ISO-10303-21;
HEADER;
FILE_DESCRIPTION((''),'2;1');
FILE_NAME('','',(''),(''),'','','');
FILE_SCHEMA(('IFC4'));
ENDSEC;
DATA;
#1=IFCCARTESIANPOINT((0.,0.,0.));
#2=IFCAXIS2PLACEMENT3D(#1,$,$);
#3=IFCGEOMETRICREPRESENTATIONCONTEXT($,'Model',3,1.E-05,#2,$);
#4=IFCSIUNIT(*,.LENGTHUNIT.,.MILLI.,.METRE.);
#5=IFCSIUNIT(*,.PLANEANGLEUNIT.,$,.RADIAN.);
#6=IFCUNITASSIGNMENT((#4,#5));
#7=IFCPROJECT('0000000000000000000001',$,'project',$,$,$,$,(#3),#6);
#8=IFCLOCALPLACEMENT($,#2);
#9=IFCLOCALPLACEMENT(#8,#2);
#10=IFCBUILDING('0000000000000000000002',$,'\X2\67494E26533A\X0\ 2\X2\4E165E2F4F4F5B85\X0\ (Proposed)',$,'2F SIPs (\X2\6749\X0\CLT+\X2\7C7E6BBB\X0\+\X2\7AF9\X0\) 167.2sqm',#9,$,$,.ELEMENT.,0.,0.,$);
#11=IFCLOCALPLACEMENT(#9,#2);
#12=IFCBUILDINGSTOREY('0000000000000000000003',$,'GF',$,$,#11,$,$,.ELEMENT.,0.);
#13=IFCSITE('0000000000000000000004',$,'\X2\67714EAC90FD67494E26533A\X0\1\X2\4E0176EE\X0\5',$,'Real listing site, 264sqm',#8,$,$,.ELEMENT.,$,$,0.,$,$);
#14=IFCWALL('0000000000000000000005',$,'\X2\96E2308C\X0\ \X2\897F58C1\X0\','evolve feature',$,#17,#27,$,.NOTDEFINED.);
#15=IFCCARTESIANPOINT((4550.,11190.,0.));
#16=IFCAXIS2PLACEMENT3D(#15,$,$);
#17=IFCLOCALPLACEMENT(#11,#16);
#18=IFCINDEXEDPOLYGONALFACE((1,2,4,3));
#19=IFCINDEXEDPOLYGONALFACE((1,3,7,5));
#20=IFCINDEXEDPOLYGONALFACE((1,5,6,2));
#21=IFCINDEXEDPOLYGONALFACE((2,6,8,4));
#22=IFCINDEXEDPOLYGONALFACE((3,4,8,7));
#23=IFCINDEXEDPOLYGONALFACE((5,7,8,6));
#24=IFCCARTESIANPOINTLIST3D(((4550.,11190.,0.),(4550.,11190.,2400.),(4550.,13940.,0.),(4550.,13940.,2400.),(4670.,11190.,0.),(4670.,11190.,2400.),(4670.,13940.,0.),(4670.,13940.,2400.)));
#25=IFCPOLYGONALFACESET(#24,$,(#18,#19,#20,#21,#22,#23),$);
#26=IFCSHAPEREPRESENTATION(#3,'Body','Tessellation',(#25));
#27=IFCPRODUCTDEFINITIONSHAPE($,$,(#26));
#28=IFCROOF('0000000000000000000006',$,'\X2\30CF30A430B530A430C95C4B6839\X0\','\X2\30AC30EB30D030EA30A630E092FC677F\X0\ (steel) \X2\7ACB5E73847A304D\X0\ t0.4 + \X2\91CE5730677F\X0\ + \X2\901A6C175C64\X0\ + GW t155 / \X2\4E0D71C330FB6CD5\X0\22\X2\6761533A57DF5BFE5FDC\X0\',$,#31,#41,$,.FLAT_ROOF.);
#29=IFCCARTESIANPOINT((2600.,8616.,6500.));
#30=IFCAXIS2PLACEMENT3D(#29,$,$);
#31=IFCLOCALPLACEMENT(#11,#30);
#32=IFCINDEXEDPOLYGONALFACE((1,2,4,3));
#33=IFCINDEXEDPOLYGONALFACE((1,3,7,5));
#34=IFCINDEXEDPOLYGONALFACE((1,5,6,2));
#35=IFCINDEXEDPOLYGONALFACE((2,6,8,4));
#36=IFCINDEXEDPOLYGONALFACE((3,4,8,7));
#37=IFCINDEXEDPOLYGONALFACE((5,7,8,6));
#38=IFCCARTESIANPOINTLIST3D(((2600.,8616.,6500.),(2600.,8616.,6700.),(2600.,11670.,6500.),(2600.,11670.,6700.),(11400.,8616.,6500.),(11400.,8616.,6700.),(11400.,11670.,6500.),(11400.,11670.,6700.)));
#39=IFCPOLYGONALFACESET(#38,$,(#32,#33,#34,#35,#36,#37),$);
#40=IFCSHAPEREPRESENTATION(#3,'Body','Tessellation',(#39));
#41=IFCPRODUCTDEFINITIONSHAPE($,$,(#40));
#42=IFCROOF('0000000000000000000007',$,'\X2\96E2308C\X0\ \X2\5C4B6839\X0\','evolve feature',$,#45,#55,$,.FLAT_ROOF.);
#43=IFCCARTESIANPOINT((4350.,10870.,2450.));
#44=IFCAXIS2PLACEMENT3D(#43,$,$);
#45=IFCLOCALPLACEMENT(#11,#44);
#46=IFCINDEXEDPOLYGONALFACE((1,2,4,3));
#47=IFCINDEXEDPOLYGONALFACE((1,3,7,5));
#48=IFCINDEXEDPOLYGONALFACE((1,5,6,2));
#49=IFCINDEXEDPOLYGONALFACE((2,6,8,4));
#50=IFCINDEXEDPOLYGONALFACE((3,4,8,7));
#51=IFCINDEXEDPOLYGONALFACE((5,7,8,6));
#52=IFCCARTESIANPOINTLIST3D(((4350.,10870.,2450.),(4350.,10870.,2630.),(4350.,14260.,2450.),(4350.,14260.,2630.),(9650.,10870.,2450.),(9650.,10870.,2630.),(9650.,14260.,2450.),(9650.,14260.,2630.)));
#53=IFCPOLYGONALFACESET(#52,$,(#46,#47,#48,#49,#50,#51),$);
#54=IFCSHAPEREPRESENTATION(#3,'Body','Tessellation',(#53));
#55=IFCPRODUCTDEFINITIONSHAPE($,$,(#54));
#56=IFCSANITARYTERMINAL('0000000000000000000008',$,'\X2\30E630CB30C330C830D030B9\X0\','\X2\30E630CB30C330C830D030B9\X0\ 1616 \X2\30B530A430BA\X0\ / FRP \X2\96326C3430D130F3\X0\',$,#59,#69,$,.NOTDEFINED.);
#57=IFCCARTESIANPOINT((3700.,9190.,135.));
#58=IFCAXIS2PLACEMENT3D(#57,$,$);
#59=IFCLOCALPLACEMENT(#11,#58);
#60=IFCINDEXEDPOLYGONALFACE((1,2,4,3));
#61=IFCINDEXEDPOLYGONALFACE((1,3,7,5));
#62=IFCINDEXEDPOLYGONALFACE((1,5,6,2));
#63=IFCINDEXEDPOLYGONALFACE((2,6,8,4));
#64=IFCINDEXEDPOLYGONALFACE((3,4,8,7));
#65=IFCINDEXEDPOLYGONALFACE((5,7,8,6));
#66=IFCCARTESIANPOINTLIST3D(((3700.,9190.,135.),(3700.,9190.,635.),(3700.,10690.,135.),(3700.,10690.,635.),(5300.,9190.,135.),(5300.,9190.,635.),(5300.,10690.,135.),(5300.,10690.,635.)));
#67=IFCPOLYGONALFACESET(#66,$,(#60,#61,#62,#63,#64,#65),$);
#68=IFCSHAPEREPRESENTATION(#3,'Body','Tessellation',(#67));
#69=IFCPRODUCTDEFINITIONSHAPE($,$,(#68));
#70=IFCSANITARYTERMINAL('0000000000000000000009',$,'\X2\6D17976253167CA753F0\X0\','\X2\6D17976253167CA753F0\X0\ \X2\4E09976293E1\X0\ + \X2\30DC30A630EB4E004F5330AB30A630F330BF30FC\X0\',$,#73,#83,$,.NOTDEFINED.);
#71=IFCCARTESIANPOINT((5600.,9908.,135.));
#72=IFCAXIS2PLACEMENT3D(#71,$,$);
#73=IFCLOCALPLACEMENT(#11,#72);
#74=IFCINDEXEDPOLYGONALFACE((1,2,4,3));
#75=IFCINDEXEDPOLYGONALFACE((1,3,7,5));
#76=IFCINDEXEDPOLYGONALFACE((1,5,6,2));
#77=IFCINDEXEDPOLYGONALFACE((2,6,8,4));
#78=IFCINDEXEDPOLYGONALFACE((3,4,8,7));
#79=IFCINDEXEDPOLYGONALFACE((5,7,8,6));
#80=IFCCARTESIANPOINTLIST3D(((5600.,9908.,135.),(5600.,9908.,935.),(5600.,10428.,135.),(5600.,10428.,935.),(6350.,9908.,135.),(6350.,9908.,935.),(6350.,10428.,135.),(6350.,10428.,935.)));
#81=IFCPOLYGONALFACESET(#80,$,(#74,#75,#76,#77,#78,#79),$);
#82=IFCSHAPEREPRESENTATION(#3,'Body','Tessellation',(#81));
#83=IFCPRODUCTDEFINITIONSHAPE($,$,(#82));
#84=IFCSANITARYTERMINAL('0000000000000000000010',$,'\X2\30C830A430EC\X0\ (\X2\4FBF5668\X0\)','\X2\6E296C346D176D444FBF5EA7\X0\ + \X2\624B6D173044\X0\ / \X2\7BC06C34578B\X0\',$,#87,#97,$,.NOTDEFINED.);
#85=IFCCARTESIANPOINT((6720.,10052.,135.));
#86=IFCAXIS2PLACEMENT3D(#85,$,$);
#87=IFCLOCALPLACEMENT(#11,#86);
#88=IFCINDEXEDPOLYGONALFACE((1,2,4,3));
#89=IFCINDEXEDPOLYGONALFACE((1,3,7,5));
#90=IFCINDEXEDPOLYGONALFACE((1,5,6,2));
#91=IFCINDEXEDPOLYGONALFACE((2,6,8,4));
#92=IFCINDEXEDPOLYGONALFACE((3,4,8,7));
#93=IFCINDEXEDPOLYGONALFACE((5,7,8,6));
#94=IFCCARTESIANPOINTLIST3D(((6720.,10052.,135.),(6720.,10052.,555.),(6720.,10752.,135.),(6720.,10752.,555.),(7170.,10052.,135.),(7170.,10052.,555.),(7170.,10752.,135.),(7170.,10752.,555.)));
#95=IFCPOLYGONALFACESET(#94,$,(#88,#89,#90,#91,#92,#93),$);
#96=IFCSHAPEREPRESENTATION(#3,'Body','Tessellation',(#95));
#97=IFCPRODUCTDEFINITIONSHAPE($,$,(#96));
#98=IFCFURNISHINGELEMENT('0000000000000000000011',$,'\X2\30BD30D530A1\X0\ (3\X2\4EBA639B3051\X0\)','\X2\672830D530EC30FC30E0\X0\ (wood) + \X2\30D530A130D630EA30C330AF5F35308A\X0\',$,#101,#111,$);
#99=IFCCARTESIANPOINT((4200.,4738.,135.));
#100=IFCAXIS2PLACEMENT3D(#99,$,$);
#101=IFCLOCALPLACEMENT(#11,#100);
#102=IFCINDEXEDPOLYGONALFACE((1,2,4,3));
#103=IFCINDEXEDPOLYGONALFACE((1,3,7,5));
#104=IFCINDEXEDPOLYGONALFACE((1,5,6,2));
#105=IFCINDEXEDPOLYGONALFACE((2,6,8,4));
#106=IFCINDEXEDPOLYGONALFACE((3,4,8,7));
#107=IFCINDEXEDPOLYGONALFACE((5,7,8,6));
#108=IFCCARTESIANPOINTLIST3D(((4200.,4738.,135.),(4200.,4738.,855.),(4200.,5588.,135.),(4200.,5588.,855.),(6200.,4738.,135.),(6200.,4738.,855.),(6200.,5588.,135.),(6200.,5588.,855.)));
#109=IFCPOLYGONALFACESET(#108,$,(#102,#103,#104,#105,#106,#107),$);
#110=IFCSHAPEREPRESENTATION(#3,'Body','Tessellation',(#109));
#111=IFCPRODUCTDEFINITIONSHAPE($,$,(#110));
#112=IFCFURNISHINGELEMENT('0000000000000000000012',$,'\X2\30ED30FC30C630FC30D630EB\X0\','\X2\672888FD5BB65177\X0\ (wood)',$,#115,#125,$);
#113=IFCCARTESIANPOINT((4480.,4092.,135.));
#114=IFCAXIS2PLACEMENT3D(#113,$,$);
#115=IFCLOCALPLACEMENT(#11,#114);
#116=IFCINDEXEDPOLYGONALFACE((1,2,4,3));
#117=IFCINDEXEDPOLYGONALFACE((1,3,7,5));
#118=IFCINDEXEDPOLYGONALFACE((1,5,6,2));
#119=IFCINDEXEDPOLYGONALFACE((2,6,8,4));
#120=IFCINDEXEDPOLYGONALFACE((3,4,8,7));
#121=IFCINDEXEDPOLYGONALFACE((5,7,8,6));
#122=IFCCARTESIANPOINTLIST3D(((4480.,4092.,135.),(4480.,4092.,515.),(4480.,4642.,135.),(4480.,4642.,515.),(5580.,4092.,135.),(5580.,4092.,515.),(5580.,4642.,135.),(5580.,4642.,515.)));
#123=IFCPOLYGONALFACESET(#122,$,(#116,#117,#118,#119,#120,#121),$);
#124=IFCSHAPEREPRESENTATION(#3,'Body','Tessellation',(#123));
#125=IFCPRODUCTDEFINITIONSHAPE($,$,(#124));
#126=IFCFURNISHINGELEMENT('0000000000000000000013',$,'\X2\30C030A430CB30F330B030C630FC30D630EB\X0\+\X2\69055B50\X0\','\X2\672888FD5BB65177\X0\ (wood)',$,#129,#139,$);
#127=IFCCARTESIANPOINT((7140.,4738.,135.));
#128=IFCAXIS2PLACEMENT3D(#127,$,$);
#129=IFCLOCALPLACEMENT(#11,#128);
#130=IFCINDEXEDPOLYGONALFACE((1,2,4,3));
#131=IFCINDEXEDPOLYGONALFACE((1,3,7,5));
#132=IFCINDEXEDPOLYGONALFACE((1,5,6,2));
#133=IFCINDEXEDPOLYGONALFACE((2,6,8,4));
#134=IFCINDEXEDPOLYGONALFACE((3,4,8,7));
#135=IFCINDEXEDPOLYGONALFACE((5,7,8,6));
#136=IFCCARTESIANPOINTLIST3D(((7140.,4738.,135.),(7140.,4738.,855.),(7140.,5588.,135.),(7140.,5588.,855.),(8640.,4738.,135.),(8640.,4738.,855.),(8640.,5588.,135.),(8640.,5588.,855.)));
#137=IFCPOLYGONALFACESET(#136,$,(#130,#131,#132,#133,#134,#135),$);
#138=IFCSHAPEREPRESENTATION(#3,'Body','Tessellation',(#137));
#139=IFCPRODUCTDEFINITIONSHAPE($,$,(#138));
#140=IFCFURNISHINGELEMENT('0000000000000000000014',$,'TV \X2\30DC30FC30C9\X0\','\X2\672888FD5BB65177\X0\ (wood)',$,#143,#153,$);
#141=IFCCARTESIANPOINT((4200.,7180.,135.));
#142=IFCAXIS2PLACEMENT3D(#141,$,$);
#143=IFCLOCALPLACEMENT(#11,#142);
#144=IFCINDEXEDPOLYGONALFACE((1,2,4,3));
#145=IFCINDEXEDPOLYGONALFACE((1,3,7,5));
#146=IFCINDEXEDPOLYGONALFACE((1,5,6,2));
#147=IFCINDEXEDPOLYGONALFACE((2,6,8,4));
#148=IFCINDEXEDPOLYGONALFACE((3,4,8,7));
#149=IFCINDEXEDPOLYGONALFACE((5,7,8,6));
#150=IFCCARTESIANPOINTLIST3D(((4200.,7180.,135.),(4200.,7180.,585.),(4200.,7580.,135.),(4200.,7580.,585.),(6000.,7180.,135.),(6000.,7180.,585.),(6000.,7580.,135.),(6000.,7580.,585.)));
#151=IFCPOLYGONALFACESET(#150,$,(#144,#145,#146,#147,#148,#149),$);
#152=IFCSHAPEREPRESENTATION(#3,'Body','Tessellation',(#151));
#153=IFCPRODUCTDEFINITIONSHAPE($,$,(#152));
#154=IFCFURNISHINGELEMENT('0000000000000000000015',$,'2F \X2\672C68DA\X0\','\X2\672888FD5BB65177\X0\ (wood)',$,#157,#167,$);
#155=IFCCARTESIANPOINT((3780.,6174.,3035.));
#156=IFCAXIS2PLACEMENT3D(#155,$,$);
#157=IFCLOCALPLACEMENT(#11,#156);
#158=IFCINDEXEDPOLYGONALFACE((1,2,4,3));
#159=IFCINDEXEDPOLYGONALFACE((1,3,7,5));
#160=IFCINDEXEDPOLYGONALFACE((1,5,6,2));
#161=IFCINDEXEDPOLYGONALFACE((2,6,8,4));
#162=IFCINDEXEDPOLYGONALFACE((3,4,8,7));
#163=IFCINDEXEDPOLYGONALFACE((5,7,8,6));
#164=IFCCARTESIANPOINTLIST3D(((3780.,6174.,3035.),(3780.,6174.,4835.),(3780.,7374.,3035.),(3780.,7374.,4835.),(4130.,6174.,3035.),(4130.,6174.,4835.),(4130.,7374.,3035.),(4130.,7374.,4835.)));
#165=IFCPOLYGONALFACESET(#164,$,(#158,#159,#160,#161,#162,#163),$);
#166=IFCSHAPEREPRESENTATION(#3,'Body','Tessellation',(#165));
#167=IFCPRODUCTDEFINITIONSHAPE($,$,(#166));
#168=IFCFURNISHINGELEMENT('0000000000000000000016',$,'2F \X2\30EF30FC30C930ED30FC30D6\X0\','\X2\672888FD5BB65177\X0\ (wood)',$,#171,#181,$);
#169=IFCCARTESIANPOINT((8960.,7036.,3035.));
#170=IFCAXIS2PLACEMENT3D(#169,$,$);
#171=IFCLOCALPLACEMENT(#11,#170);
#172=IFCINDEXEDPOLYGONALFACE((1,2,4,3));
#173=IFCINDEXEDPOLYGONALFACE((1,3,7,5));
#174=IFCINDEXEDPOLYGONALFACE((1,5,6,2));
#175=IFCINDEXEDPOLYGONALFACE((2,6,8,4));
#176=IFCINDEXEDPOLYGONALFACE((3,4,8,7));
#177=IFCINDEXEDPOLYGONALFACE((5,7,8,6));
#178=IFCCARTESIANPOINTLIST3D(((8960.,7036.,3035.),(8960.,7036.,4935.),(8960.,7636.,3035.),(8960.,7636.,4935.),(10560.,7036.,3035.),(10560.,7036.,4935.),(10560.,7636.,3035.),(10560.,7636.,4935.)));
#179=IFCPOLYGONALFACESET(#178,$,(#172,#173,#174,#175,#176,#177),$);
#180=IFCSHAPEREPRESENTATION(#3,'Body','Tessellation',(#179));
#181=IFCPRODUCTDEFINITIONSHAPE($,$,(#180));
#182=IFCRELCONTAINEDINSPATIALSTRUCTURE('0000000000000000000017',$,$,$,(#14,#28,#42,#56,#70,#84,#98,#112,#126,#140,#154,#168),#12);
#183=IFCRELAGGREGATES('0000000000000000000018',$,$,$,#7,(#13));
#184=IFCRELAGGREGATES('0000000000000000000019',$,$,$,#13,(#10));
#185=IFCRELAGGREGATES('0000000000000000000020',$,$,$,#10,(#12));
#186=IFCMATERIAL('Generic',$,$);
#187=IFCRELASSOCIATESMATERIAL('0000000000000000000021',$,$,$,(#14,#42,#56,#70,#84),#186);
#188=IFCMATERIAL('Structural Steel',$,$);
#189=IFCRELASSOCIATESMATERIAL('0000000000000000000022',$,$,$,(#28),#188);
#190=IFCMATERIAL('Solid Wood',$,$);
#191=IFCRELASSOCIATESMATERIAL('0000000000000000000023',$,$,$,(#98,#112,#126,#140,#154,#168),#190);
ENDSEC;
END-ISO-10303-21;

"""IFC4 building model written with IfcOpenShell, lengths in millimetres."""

from ifc_helpers import new_model, si_unit, frame, frame_2d, origin, place, context, project, spatial, rectangle, extrude, material, element, save


model = new_model("IFC4")

# Units and contexts
model_context = context("Model", 3, precision=1e-05, world=origin())
ifc_project = project(units=[si_unit("LENGTHUNIT", "METRE", prefix="MILLI"), si_unit("PLANEANGLEUNIT", "RADIAN")], contexts=[model_context])

# Site, building, storey
site_placement = place(None, origin())
site = spatial("IfcSite", under=ifc_project, at=site_placement, Name="東京都杉並区1丁目5", ObjectType="Real listing site, 264sqm", CompositionType="ELEMENT", RefElevation=0.0)
building_placement = place(site_placement, origin())
building = spatial("IfcBuilding", under=site, at=building_placement, Name="杉並区 2世帯住宅 (Proposed)", ObjectType="2F SIPs (杉CLT+籾殻+竹) 167.2sqm", CompositionType="ELEMENT", ElevationOfRefHeight=0.0, ElevationOfTerrain=0.0)
storey_placement = place(building_placement, origin())
storey = spatial("IfcBuildingStorey", under=building, at=storey_placement, Name="GF", CompositionType="ELEMENT", Elevation=0.0)

# Shared definitions
ifc_material_1 = material(Name="Generic")

# Shared definitions
ifc_material_2 = material(Name="Solid Wood")

# Wall
wall_1_placement = place(storey_placement, frame((4550.0, 11190.0, 0.0)))
element("IfcWall", 1, at=wall_1_placement, inside=storey, material=ifc_material_1, Name="離れ 西壁", Description="evolve feature", PredefinedType="NOTDEFINED", context=model_context, shape_type="SweptSolid", body=[
    extrude(rectangle(XDim=120.0, YDim=2750.0, at=frame_2d((60.0, 1375.0))), frame((4550.0, 11190.0, 0.0)), (0.0, 0.0, 1.0), 2400.0),
])

# Roofs
ifc_material_3 = material(Name="Structural Steel")
roof_1_placement = place(storey_placement, frame((2600.0, 8616.0, 6500.0)))
element("IfcRoof", 2, at=roof_1_placement, inside=storey, material=ifc_material_3, Name="ハイサイド屋根", Description="ガルバリウム鋼板 (steel) 立平葺き t0.4 + 野地板 + 通気層 + GW t155 / 不燃・法22条区域対応", PredefinedType="FLAT_ROOF", context=model_context, shape_type="SweptSolid", body=[
    extrude(rectangle(XDim=8800.0, YDim=3054.0, at=frame_2d((4400.0, 1527.0))), frame((2600.0, 8616.0, 6500.0)), (0.0, 0.0, 1.0), 200.0),
])
roof_2_placement = place(storey_placement, frame((4350.0, 10870.0, 2450.0)))
element("IfcRoof", 3, at=roof_2_placement, inside=storey, material=ifc_material_1, Name="離れ 屋根", Description="evolve feature", PredefinedType="FLAT_ROOF", context=model_context, shape_type="SweptSolid", body=[
    extrude(rectangle(XDim=5300.0, YDim=3390.0, at=frame_2d((2650.0, 1695.0))), frame((4350.0, 10870.0, 2450.0)), (0.0, 0.0, 1.0), 180.0),
])

# Sanitary terminals
sanitary_terminal_1_placement = place(storey_placement, frame((3700.0, 9190.0, 135.0)))
element("IfcSanitaryTerminal", 4, at=sanitary_terminal_1_placement, inside=storey, material=ifc_material_1, Name="ユニットバス", Description="ユニットバス 1616 サイズ / FRP 防水パン", PredefinedType="NOTDEFINED", context=model_context, shape_type="SweptSolid", body=[
    extrude(rectangle(XDim=1600.0, YDim=1500.0, at=frame_2d((800.0, 750.0))), frame((3700.0, 9190.0, 135.0)), (0.0, 0.0, 1.0), 500.0),
])
sanitary_terminal_2_placement = place(storey_placement, frame((5600.0, 9908.0, 135.0)))
element("IfcSanitaryTerminal", 5, at=sanitary_terminal_2_placement, inside=storey, material=ifc_material_1, Name="洗面化粧台", Description="洗面化粧台 三面鏡 + ボウル一体カウンター", PredefinedType="NOTDEFINED", context=model_context, shape_type="SweptSolid", body=[
    extrude(rectangle(XDim=750.0, YDim=520.0, at=frame_2d((375.0, 260.0))), frame((5600.0, 9908.0, 135.0)), (0.0, 0.0, 1.0), 800.0),
])
sanitary_terminal_3_placement = place(storey_placement, frame((6720.0, 10052.0, 135.0)))
element("IfcSanitaryTerminal", 6, at=sanitary_terminal_3_placement, inside=storey, material=ifc_material_1, Name="トイレ (便器)", Description="温水洗浄便座 + 手洗い / 節水型", PredefinedType="NOTDEFINED", context=model_context, shape_type="SweptSolid", body=[
    extrude(rectangle(XDim=450.0, YDim=700.0, at=frame_2d((225.0, 350.0))), frame((6720.0, 10052.0, 135.0)), (0.0, 0.0, 1.0), 420.0),
])

# Furnishing elements
furnishing_1_placement = place(storey_placement, frame((4200.0, 4738.0, 135.0)))
element("IfcFurnishingElement", 7, at=furnishing_1_placement, inside=storey, material=ifc_material_2, Name="ソファ (3人掛け)", Description="木フレーム (wood) + ファブリック張り", context=model_context, shape_type="SweptSolid", body=[
    extrude(rectangle(XDim=2000.0, YDim=850.0, at=frame_2d((1000.0, 425.0))), frame((4200.0, 4738.0, 135.0)), (0.0, 0.0, 1.0), 720.0),
])
furnishing_2_placement = place(storey_placement, frame((4480.0, 4092.0, 135.0)))
element("IfcFurnishingElement", 8, at=furnishing_2_placement, inside=storey, material=ifc_material_2, Name="ローテーブル", Description="木製家具 (wood)", context=model_context, shape_type="SweptSolid", body=[
    extrude(rectangle(XDim=1100.0, YDim=550.0, at=frame_2d((550.0, 275.0))), frame((4480.0, 4092.0, 135.0)), (0.0, 0.0, 1.0), 380.0),
])
furnishing_3_placement = place(storey_placement, frame((7140.0, 4738.0, 135.0)))
element("IfcFurnishingElement", 9, at=furnishing_3_placement, inside=storey, material=ifc_material_2, Name="ダイニングテーブル+椅子", Description="木製家具 (wood)", context=model_context, shape_type="SweptSolid", body=[
    extrude(rectangle(XDim=1500.0, YDim=850.0, at=frame_2d((750.0, 425.0))), frame((7140.0, 4738.0, 135.0)), (0.0, 0.0, 1.0), 720.0),
])
furnishing_4_placement = place(storey_placement, frame((4200.0, 7180.0, 135.0)))
element("IfcFurnishingElement", 10, at=furnishing_4_placement, inside=storey, material=ifc_material_2, Name="TV ボード", Description="木製家具 (wood)", context=model_context, shape_type="SweptSolid", body=[
    extrude(rectangle(XDim=1800.0, YDim=400.0, at=frame_2d((900.0, 200.0))), frame((4200.0, 7180.0, 135.0)), (0.0, 0.0, 1.0), 450.0),
])
furnishing_5_placement = place(storey_placement, frame((3780.0, 6174.0, 3035.0)))
element("IfcFurnishingElement", 11, at=furnishing_5_placement, inside=storey, material=ifc_material_2, Name="2F 本棚", Description="木製家具 (wood)", context=model_context, shape_type="SweptSolid", body=[
    extrude(rectangle(XDim=350.0, YDim=1200.0, at=frame_2d((175.0, 600.0))), frame((3780.0, 6174.0, 3035.0)), (0.0, 0.0, 1.0), 1800.0),
])
furnishing_6_placement = place(storey_placement, frame((8960.0, 7036.0, 3035.0)))
element("IfcFurnishingElement", 12, at=furnishing_6_placement, inside=storey, material=ifc_material_2, Name="2F ワードローブ", Description="木製家具 (wood)", context=model_context, shape_type="SweptSolid", body=[
    extrude(rectangle(XDim=1600.0, YDim=600.0, at=frame_2d((800.0, 300.0))), frame((8960.0, 7036.0, 3035.0)), (0.0, 0.0, 1.0), 1900.0),
])

save(model, "model.ifc")
